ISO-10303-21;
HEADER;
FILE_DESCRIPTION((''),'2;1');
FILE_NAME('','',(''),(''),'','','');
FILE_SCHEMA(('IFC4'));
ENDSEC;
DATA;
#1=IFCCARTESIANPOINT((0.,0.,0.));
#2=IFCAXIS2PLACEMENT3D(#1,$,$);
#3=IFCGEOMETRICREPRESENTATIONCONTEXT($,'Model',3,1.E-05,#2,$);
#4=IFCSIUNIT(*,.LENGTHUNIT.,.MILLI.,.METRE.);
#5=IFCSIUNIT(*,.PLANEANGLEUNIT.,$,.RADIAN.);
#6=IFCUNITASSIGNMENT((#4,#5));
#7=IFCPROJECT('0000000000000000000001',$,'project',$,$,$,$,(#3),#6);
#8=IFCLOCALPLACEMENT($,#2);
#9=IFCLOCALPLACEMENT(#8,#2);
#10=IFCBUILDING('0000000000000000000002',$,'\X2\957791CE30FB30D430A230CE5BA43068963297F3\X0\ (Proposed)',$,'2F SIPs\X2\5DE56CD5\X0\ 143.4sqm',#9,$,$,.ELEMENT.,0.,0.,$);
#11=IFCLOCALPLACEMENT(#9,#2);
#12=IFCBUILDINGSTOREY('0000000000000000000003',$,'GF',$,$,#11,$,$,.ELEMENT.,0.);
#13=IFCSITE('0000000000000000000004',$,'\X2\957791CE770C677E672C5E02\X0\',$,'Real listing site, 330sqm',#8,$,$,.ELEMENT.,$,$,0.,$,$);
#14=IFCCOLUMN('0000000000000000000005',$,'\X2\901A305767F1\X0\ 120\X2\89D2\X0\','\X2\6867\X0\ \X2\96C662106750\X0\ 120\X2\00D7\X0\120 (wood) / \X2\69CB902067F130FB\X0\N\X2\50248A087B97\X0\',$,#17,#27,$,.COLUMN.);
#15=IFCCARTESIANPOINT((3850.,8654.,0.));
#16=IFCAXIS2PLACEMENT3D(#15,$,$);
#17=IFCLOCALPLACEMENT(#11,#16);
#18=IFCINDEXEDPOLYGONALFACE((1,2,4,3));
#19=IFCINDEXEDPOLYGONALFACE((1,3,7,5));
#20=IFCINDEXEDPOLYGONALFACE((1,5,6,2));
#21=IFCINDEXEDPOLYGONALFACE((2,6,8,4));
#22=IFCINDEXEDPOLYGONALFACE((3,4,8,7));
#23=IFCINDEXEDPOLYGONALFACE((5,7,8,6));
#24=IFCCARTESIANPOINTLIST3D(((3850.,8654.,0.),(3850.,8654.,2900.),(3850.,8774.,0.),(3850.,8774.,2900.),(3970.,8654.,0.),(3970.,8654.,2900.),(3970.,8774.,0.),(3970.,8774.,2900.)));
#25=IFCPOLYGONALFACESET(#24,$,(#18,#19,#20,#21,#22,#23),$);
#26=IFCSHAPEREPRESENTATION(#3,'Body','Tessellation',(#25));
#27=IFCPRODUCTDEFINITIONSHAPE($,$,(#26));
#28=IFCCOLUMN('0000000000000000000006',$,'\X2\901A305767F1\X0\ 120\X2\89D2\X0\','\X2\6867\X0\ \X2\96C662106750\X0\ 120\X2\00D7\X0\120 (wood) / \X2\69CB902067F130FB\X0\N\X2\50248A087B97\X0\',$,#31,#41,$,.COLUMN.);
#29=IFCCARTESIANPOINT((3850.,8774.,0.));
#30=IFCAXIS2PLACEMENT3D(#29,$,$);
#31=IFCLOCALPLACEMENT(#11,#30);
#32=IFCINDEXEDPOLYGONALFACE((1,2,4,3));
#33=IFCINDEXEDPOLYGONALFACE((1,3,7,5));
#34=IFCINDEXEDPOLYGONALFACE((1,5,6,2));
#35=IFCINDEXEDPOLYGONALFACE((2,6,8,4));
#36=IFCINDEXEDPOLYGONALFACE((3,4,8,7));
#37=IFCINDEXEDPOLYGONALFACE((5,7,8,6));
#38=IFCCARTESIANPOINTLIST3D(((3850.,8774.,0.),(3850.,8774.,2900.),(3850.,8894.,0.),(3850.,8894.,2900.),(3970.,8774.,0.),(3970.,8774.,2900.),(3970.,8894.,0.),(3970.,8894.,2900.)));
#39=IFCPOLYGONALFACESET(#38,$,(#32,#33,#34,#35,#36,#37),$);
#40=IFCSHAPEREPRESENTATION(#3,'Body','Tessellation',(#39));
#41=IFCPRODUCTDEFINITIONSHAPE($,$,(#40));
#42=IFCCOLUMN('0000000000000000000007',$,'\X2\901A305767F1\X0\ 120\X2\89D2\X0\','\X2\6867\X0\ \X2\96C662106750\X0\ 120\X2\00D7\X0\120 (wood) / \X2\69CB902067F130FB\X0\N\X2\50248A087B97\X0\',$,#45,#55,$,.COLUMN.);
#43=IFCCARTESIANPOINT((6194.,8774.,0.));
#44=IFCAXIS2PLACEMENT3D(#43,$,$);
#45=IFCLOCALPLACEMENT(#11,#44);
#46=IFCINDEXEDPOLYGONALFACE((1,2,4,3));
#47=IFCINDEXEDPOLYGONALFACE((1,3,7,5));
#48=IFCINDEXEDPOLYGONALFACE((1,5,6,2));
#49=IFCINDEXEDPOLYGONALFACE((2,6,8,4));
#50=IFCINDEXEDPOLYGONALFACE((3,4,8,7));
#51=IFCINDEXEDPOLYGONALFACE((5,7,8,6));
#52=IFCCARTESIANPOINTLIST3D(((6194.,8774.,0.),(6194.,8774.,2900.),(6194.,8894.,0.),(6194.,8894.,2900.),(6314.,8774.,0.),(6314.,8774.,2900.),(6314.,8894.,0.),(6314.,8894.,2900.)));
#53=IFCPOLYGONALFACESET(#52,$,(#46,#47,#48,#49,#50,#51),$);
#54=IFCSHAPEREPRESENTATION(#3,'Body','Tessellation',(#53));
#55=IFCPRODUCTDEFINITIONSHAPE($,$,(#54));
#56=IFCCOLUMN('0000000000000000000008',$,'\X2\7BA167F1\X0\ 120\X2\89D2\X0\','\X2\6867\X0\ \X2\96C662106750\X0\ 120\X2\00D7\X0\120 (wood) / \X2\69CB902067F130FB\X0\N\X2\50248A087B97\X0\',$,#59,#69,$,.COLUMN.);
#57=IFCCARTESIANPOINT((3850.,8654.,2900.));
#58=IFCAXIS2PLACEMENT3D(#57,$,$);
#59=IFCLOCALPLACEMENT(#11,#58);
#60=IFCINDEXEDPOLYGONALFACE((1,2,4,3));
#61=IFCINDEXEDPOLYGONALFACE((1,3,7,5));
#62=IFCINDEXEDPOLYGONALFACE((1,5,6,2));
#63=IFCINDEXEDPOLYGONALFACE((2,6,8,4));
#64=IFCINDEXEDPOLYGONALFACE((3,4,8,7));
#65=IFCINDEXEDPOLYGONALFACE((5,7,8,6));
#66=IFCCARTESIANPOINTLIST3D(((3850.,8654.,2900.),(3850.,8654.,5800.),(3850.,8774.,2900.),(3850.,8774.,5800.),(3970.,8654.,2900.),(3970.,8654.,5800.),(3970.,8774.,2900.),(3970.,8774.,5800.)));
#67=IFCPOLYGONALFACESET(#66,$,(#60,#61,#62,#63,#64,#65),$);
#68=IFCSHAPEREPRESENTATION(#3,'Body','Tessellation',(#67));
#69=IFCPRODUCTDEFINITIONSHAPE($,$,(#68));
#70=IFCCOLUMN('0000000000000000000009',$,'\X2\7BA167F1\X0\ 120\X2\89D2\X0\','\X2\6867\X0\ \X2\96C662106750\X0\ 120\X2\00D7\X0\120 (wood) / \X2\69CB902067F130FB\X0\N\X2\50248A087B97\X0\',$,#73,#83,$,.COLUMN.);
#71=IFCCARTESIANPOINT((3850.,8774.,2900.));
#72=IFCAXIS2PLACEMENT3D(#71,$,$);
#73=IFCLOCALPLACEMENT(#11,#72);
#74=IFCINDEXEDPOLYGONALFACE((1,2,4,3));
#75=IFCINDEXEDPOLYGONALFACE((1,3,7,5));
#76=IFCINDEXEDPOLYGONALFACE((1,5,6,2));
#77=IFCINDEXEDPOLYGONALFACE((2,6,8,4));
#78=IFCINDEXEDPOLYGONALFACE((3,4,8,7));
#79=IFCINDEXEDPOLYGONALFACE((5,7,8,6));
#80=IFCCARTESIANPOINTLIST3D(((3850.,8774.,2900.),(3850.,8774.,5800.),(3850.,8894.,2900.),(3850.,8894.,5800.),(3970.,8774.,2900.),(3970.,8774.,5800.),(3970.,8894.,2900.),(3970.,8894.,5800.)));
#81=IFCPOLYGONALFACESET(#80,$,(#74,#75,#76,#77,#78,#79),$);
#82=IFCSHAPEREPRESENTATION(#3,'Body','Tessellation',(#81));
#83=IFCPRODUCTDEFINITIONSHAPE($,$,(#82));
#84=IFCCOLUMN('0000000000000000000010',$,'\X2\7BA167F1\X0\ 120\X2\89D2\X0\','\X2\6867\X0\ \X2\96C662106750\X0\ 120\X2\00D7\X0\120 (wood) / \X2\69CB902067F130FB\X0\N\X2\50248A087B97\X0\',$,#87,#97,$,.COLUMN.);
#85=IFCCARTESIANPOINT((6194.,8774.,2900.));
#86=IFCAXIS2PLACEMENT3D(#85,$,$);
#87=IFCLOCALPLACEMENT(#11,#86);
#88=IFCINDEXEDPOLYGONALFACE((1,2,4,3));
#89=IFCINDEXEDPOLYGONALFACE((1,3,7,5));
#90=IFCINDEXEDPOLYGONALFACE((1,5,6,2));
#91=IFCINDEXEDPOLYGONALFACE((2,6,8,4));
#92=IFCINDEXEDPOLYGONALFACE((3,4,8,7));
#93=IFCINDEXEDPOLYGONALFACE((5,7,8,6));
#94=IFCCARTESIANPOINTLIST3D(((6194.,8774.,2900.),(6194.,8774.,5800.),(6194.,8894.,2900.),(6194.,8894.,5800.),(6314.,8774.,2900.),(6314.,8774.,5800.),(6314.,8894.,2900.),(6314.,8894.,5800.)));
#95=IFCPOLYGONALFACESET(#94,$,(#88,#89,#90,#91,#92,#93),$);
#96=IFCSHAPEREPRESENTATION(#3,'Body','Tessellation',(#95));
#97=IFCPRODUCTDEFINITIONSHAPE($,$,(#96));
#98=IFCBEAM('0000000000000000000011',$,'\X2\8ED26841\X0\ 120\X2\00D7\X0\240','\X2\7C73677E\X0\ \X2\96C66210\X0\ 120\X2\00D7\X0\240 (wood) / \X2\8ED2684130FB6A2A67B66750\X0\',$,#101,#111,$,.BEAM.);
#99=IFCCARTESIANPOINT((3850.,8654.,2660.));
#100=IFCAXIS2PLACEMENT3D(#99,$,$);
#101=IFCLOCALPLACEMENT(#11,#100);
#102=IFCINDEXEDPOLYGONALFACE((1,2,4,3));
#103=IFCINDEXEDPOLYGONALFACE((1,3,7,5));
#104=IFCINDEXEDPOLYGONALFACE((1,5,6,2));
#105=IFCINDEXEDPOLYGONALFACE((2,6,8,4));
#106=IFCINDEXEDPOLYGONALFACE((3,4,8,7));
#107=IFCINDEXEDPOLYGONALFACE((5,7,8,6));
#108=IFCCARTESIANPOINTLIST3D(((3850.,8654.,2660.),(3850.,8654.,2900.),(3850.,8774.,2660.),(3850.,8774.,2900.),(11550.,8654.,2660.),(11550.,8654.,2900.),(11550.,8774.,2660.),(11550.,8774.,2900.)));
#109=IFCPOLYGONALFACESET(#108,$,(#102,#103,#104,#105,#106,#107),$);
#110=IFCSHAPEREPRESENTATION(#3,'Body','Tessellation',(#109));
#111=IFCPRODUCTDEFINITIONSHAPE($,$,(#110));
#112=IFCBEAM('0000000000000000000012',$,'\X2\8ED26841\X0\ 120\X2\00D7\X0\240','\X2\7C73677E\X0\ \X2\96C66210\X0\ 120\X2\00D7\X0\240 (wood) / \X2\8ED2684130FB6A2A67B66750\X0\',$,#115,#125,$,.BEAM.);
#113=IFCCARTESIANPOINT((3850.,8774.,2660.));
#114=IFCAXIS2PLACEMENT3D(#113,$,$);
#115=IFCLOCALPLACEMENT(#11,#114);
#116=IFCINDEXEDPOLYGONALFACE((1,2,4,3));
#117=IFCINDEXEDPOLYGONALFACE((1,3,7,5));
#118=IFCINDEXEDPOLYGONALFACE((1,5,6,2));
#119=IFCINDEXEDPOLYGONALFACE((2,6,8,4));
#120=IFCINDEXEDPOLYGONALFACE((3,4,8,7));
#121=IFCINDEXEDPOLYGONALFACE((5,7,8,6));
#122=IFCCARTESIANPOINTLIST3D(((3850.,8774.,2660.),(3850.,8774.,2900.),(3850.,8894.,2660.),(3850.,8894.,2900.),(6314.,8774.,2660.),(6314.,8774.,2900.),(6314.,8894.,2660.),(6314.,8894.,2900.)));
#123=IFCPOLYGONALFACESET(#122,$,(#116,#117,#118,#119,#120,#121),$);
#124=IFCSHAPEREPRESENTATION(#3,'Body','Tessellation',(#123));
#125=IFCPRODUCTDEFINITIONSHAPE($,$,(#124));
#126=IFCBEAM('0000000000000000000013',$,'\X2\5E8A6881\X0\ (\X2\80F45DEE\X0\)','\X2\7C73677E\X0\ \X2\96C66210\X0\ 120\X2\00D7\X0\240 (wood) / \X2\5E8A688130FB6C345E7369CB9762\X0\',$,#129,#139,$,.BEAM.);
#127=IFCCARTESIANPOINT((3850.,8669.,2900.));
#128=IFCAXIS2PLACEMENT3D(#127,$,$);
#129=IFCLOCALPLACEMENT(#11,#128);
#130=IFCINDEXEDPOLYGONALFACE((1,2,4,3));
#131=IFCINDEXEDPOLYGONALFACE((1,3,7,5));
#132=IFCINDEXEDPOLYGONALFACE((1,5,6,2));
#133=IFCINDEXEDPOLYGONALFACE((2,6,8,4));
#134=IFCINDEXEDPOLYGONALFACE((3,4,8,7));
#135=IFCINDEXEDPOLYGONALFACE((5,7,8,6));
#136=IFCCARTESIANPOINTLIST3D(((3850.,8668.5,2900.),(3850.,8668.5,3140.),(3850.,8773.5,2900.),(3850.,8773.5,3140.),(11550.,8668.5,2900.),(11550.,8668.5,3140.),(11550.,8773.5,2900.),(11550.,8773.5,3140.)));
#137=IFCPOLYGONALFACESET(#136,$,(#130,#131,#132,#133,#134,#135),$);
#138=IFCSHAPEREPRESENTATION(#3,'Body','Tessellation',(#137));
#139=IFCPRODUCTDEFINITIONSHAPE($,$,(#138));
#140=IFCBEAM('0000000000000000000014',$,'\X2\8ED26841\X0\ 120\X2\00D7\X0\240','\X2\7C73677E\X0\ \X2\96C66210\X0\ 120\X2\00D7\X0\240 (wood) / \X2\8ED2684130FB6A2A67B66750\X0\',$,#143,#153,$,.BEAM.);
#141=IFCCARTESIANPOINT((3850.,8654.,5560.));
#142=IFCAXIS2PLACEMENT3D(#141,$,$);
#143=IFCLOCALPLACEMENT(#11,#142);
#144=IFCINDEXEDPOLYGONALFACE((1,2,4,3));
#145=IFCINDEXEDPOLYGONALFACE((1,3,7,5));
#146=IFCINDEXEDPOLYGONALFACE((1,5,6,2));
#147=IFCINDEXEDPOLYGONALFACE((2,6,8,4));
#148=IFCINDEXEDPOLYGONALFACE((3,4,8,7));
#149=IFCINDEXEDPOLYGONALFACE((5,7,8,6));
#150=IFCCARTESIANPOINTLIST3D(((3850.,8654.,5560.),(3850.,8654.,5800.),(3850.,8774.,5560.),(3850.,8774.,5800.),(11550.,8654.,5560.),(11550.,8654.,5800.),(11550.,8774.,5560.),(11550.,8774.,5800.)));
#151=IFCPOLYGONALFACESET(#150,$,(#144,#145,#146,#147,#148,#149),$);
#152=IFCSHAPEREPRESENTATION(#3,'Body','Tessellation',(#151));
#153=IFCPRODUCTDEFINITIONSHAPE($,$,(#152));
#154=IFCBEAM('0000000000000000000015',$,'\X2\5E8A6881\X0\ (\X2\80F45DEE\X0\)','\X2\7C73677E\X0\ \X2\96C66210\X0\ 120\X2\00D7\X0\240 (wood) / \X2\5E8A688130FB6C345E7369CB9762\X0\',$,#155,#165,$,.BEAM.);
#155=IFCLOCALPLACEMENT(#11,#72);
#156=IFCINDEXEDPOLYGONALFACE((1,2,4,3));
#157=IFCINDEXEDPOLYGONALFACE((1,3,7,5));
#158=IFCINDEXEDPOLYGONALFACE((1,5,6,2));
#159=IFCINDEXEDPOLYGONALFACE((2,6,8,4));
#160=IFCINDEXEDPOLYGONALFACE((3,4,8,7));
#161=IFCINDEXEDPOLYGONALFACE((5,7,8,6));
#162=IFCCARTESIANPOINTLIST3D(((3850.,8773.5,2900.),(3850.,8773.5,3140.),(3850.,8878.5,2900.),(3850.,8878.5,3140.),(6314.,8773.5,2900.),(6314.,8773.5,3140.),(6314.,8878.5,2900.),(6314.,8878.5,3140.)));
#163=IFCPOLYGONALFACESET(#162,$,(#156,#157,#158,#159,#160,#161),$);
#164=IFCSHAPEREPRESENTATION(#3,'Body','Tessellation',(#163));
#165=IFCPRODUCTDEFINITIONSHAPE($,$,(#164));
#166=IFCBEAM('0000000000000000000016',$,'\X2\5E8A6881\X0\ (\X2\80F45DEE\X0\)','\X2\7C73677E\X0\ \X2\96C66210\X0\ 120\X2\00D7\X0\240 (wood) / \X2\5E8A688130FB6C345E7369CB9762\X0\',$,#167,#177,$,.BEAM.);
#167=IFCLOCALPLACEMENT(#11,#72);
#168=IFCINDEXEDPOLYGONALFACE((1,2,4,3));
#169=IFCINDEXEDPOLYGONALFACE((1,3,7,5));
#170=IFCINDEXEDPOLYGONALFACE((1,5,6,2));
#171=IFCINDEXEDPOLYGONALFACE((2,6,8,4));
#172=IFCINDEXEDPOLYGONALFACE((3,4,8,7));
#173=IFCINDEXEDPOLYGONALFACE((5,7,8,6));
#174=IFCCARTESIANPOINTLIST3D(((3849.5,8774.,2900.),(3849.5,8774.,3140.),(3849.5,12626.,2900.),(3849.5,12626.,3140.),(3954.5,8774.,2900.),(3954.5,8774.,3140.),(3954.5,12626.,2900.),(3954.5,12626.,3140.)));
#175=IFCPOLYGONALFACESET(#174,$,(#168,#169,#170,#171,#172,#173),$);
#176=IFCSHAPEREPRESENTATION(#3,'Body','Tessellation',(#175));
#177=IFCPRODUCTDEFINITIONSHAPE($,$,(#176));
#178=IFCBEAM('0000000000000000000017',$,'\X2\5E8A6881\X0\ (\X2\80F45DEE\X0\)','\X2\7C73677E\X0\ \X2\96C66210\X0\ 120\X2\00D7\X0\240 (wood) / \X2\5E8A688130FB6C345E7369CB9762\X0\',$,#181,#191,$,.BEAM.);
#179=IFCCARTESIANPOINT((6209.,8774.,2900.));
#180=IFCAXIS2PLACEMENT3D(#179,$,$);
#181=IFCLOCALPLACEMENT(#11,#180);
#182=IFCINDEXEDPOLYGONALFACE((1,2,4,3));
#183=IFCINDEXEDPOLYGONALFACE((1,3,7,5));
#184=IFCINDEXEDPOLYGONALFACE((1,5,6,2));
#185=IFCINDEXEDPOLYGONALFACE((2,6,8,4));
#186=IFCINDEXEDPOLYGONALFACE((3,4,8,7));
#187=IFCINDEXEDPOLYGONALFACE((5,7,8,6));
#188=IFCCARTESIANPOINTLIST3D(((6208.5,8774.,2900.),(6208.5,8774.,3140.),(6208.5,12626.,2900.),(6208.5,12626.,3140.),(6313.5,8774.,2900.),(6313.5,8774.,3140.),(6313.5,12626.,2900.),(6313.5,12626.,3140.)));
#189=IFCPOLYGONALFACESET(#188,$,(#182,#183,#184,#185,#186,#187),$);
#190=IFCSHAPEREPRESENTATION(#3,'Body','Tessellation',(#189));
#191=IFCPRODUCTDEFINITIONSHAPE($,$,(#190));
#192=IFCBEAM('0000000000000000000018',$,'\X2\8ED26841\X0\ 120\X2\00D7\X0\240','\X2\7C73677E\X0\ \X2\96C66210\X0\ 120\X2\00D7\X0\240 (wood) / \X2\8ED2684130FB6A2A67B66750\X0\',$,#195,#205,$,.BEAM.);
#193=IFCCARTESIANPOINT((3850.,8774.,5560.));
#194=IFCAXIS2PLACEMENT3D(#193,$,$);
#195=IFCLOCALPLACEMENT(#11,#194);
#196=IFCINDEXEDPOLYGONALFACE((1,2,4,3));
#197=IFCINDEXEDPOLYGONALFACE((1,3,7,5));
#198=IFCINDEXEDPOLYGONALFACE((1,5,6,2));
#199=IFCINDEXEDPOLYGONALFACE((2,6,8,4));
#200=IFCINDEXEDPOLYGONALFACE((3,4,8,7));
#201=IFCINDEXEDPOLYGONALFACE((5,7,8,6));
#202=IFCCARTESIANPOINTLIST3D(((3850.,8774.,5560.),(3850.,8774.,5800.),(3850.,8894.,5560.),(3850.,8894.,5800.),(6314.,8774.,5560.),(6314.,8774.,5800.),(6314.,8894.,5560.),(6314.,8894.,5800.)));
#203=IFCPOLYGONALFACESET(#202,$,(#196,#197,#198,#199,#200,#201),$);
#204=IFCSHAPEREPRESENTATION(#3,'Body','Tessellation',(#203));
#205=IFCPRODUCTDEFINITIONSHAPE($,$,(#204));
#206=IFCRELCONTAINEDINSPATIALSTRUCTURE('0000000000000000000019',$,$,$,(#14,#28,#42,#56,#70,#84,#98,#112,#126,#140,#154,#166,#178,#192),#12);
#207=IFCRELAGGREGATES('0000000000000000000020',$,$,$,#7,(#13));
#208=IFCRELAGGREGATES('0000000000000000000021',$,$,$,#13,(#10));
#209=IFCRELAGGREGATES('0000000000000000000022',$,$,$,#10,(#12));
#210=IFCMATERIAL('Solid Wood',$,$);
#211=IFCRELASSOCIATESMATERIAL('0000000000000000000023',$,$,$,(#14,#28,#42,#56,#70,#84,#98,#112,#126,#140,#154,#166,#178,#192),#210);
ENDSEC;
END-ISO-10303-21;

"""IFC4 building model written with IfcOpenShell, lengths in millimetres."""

from ifc_helpers import new_model, si_unit, frame, frame_2d, origin, place, context, project, spatial, rectangle, extrude, material, element, save


model = new_model("IFC4")

# Units and contexts
model_context = context("Model", 3, precision=1e-05, world=origin())
ifc_project = project(units=[si_unit("LENGTHUNIT", "METRE", prefix="MILLI"), si_unit("PLANEANGLEUNIT", "RADIAN")], contexts=[model_context])

# Site, building, storey
site_placement = place(None, origin())
site = spatial("IfcSite", under=ifc_project, at=site_placement, Name="長野県松本市", ObjectType="Real listing site, 330sqm", CompositionType="ELEMENT", RefElevation=0.0)
building_placement = place(site_placement, origin())
building = spatial("IfcBuilding", under=site, at=building_placement, Name="長野・ピアノ室と防音 (Proposed)", ObjectType="2F SIPs工法 143.4sqm", CompositionType="ELEMENT", ElevationOfRefHeight=0.0, ElevationOfTerrain=0.0)
storey_placement = place(building_placement, origin())
storey = spatial("IfcBuildingStorey", under=building, at=storey_placement, Name="GF", CompositionType="ELEMENT", Elevation=0.0)

# Columns
ifc_material_1 = material(Name="Solid Wood")
column_1_placement = place(storey_placement, frame((3850.0, 8654.0, 0.0)))
element("IfcColumn", 1, at=column_1_placement, inside=storey, material=ifc_material_1, Name="通し柱 120角", Description="桧 集成材 120×120 (wood) / 構造柱・N値計算", PredefinedType="COLUMN", context=model_context, shape_type="SweptSolid", body=[
    extrude(rectangle(XDim=120.0, YDim=120.0, at=frame_2d((60.0, 60.0))), frame((3850.0, 8654.0, 0.0)), (0.0, 0.0, 1.0), 2900.0),
])
column_2_placement = place(storey_placement, frame((3850.0, 8774.0, 0.0)))
element("IfcColumn", 2, at=column_2_placement, inside=storey, material=ifc_material_1, Name="通し柱 120角", Description="桧 集成材 120×120 (wood) / 構造柱・N値計算", PredefinedType="COLUMN", context=model_context, shape_type="SweptSolid", body=[
    extrude(rectangle(XDim=120.0, YDim=120.0, at=frame_2d((60.0, 60.0))), frame((3850.0, 8774.0, 0.0)), (0.0, 0.0, 1.0), 2900.0),
])
column_3_placement = place(storey_placement, frame((6194.0, 8774.0, 0.0)))
element("IfcColumn", 3, at=column_3_placement, inside=storey, material=ifc_material_1, Name="通し柱 120角", Description="桧 集成材 120×120 (wood) / 構造柱・N値計算", PredefinedType="COLUMN", context=model_context, shape_type="SweptSolid", body=[
    extrude(rectangle(XDim=120.0, YDim=120.0, at=frame_2d((60.0, 60.0))), frame((6194.0, 8774.0, 0.0)), (0.0, 0.0, 1.0), 2900.0),
])
column_4_placement = place(storey_placement, frame((3850.0, 8654.0, 2900.0)))
element("IfcColumn", 4, at=column_4_placement, inside=storey, material=ifc_material_1, Name="管柱 120角", Description="桧 集成材 120×120 (wood) / 構造柱・N値計算", PredefinedType="COLUMN", context=model_context, shape_type="SweptSolid", body=[
    extrude(rectangle(XDim=120.0, YDim=120.0, at=frame_2d((60.0, 60.0))), frame((3850.0, 8654.0, 2900.0)), (0.0, 0.0, 1.0), 2900.0),
])
column_5_placement = place(storey_placement, frame((3850.0, 8774.0, 2900.0)))
element("IfcColumn", 5, at=column_5_placement, inside=storey, material=ifc_material_1, Name="管柱 120角", Description="桧 集成材 120×120 (wood) / 構造柱・N値計算", PredefinedType="COLUMN", context=model_context, shape_type="SweptSolid", body=[
    extrude(rectangle(XDim=120.0, YDim=120.0, at=frame_2d((60.0, 60.0))), frame((3850.0, 8774.0, 2900.0)), (0.0, 0.0, 1.0), 2900.0),
])
column_6_placement = place(storey_placement, frame((6194.0, 8774.0, 2900.0)))
element("IfcColumn", 6, at=column_6_placement, inside=storey, material=ifc_material_1, Name="管柱 120角", Description="桧 集成材 120×120 (wood) / 構造柱・N値計算", PredefinedType="COLUMN", context=model_context, shape_type="SweptSolid", body=[
    extrude(rectangle(XDim=120.0, YDim=120.0, at=frame_2d((60.0, 60.0))), frame((6194.0, 8774.0, 2900.0)), (0.0, 0.0, 1.0), 2900.0),
])

# Beams
beam_1_placement = place(storey_placement, frame((3850.0, 8654.0, 2660.0)))
element("IfcBeam", 7, at=beam_1_placement, inside=storey, material=ifc_material_1, Name="軒桁 120×240", Description="米松 集成 120×240 (wood) / 軒桁・横架材", PredefinedType="BEAM", context=model_context, shape_type="SweptSolid", body=[
    extrude(rectangle(XDim=7700.0, YDim=120.0, at=frame_2d((3850.0, 60.0))), frame((3850.0, 8654.0, 2660.0)), (0.0, 0.0, 1.0), 240.0),
])
beam_2_placement = place(storey_placement, frame((3850.0, 8774.0, 2660.0)))
element("IfcBeam", 8, at=beam_2_placement, inside=storey, material=ifc_material_1, Name="軒桁 120×240", Description="米松 集成 120×240 (wood) / 軒桁・横架材", PredefinedType="BEAM", context=model_context, shape_type="SweptSolid", body=[
    extrude(rectangle(XDim=2464.0, YDim=120.0, at=frame_2d((1232.0, 60.0))), frame((3850.0, 8774.0, 2660.0)), (0.0, 0.0, 1.0), 240.0),
])
beam_3_placement = place(storey_placement, frame((3850.0, 8669.0, 2900.0)))
element("IfcBeam", 9, at=beam_3_placement, inside=storey, material=ifc_material_1, Name="床梁 (胴差)", Description="米松 集成 120×240 (wood) / 床梁・水平構面", PredefinedType="BEAM", context=model_context, shape_type="SweptSolid", body=[
    extrude(rectangle(XDim=7700.0, YDim=105.0, at=frame_2d((3850.0, 52.0))), frame((3850.0, 8669.0, 2900.0)), (0.0, 0.0, 1.0), 240.0),
])
beam_4_placement = place(storey_placement, frame((3850.0, 8654.0, 5560.0)))
element("IfcBeam", 10, at=beam_4_placement, inside=storey, material=ifc_material_1, Name="軒桁 120×240", Description="米松 集成 120×240 (wood) / 軒桁・横架材", PredefinedType="BEAM", context=model_context, shape_type="SweptSolid", body=[
    extrude(rectangle(XDim=7700.0, YDim=120.0, at=frame_2d((3850.0, 60.0))), frame((3850.0, 8654.0, 5560.0)), (0.0, 0.0, 1.0), 240.0),
])
beam_5_placement = place(storey_placement, frame((3850.0, 8774.0, 2900.0)))
element("IfcBeam", 11, at=beam_5_placement, inside=storey, material=ifc_material_1, Name="床梁 (胴差)", Description="米松 集成 120×240 (wood) / 床梁・水平構面", PredefinedType="BEAM", context=model_context, shape_type="SweptSolid", body=[
    extrude(rectangle(XDim=2464.0, YDim=105.0, at=frame_2d((1232.0, 52.0))), frame((3850.0, 8774.0, 2900.0)), (0.0, 0.0, 1.0), 240.0),
])
beam_6_placement = place(storey_placement, frame((3850.0, 8774.0, 2900.0)))
element("IfcBeam", 12, at=beam_6_placement, inside=storey, material=ifc_material_1, Name="床梁 (胴差)", Description="米松 集成 120×240 (wood) / 床梁・水平構面", PredefinedType="BEAM", context=model_context, shape_type="SweptSolid", body=[
    extrude(rectangle(XDim=105.0, YDim=3852.0, at=frame_2d((52.0, 1926.0))), frame((3850.0, 8774.0, 2900.0)), (0.0, 0.0, 1.0), 240.0),
])
beam_7_placement = place(storey_placement, frame((6209.0, 8774.0, 2900.0)))
element("IfcBeam", 13, at=beam_7_placement, inside=storey, material=ifc_material_1, Name="床梁 (胴差)", Description="米松 集成 120×240 (wood) / 床梁・水平構面", PredefinedType="BEAM", context=model_context, shape_type="SweptSolid", body=[
    extrude(rectangle(XDim=105.0, YDim=3852.0, at=frame_2d((52.0, 1926.0))), frame((6209.0, 8774.0, 2900.0)), (0.0, 0.0, 1.0), 240.0),
])
beam_8_placement = place(storey_placement, frame((3850.0, 8774.0, 5560.0)))
element("IfcBeam", 14, at=beam_8_placement, inside=storey, material=ifc_material_1, Name="軒桁 120×240", Description="米松 集成 120×240 (wood) / 軒桁・横架材", PredefinedType="BEAM", context=model_context, shape_type="SweptSolid", body=[
    extrude(rectangle(XDim=2464.0, YDim=120.0, at=frame_2d((1232.0, 60.0))), frame((3850.0, 8774.0, 5560.0)), (0.0, 0.0, 1.0), 240.0),
])

save(model, "model.ifc")
